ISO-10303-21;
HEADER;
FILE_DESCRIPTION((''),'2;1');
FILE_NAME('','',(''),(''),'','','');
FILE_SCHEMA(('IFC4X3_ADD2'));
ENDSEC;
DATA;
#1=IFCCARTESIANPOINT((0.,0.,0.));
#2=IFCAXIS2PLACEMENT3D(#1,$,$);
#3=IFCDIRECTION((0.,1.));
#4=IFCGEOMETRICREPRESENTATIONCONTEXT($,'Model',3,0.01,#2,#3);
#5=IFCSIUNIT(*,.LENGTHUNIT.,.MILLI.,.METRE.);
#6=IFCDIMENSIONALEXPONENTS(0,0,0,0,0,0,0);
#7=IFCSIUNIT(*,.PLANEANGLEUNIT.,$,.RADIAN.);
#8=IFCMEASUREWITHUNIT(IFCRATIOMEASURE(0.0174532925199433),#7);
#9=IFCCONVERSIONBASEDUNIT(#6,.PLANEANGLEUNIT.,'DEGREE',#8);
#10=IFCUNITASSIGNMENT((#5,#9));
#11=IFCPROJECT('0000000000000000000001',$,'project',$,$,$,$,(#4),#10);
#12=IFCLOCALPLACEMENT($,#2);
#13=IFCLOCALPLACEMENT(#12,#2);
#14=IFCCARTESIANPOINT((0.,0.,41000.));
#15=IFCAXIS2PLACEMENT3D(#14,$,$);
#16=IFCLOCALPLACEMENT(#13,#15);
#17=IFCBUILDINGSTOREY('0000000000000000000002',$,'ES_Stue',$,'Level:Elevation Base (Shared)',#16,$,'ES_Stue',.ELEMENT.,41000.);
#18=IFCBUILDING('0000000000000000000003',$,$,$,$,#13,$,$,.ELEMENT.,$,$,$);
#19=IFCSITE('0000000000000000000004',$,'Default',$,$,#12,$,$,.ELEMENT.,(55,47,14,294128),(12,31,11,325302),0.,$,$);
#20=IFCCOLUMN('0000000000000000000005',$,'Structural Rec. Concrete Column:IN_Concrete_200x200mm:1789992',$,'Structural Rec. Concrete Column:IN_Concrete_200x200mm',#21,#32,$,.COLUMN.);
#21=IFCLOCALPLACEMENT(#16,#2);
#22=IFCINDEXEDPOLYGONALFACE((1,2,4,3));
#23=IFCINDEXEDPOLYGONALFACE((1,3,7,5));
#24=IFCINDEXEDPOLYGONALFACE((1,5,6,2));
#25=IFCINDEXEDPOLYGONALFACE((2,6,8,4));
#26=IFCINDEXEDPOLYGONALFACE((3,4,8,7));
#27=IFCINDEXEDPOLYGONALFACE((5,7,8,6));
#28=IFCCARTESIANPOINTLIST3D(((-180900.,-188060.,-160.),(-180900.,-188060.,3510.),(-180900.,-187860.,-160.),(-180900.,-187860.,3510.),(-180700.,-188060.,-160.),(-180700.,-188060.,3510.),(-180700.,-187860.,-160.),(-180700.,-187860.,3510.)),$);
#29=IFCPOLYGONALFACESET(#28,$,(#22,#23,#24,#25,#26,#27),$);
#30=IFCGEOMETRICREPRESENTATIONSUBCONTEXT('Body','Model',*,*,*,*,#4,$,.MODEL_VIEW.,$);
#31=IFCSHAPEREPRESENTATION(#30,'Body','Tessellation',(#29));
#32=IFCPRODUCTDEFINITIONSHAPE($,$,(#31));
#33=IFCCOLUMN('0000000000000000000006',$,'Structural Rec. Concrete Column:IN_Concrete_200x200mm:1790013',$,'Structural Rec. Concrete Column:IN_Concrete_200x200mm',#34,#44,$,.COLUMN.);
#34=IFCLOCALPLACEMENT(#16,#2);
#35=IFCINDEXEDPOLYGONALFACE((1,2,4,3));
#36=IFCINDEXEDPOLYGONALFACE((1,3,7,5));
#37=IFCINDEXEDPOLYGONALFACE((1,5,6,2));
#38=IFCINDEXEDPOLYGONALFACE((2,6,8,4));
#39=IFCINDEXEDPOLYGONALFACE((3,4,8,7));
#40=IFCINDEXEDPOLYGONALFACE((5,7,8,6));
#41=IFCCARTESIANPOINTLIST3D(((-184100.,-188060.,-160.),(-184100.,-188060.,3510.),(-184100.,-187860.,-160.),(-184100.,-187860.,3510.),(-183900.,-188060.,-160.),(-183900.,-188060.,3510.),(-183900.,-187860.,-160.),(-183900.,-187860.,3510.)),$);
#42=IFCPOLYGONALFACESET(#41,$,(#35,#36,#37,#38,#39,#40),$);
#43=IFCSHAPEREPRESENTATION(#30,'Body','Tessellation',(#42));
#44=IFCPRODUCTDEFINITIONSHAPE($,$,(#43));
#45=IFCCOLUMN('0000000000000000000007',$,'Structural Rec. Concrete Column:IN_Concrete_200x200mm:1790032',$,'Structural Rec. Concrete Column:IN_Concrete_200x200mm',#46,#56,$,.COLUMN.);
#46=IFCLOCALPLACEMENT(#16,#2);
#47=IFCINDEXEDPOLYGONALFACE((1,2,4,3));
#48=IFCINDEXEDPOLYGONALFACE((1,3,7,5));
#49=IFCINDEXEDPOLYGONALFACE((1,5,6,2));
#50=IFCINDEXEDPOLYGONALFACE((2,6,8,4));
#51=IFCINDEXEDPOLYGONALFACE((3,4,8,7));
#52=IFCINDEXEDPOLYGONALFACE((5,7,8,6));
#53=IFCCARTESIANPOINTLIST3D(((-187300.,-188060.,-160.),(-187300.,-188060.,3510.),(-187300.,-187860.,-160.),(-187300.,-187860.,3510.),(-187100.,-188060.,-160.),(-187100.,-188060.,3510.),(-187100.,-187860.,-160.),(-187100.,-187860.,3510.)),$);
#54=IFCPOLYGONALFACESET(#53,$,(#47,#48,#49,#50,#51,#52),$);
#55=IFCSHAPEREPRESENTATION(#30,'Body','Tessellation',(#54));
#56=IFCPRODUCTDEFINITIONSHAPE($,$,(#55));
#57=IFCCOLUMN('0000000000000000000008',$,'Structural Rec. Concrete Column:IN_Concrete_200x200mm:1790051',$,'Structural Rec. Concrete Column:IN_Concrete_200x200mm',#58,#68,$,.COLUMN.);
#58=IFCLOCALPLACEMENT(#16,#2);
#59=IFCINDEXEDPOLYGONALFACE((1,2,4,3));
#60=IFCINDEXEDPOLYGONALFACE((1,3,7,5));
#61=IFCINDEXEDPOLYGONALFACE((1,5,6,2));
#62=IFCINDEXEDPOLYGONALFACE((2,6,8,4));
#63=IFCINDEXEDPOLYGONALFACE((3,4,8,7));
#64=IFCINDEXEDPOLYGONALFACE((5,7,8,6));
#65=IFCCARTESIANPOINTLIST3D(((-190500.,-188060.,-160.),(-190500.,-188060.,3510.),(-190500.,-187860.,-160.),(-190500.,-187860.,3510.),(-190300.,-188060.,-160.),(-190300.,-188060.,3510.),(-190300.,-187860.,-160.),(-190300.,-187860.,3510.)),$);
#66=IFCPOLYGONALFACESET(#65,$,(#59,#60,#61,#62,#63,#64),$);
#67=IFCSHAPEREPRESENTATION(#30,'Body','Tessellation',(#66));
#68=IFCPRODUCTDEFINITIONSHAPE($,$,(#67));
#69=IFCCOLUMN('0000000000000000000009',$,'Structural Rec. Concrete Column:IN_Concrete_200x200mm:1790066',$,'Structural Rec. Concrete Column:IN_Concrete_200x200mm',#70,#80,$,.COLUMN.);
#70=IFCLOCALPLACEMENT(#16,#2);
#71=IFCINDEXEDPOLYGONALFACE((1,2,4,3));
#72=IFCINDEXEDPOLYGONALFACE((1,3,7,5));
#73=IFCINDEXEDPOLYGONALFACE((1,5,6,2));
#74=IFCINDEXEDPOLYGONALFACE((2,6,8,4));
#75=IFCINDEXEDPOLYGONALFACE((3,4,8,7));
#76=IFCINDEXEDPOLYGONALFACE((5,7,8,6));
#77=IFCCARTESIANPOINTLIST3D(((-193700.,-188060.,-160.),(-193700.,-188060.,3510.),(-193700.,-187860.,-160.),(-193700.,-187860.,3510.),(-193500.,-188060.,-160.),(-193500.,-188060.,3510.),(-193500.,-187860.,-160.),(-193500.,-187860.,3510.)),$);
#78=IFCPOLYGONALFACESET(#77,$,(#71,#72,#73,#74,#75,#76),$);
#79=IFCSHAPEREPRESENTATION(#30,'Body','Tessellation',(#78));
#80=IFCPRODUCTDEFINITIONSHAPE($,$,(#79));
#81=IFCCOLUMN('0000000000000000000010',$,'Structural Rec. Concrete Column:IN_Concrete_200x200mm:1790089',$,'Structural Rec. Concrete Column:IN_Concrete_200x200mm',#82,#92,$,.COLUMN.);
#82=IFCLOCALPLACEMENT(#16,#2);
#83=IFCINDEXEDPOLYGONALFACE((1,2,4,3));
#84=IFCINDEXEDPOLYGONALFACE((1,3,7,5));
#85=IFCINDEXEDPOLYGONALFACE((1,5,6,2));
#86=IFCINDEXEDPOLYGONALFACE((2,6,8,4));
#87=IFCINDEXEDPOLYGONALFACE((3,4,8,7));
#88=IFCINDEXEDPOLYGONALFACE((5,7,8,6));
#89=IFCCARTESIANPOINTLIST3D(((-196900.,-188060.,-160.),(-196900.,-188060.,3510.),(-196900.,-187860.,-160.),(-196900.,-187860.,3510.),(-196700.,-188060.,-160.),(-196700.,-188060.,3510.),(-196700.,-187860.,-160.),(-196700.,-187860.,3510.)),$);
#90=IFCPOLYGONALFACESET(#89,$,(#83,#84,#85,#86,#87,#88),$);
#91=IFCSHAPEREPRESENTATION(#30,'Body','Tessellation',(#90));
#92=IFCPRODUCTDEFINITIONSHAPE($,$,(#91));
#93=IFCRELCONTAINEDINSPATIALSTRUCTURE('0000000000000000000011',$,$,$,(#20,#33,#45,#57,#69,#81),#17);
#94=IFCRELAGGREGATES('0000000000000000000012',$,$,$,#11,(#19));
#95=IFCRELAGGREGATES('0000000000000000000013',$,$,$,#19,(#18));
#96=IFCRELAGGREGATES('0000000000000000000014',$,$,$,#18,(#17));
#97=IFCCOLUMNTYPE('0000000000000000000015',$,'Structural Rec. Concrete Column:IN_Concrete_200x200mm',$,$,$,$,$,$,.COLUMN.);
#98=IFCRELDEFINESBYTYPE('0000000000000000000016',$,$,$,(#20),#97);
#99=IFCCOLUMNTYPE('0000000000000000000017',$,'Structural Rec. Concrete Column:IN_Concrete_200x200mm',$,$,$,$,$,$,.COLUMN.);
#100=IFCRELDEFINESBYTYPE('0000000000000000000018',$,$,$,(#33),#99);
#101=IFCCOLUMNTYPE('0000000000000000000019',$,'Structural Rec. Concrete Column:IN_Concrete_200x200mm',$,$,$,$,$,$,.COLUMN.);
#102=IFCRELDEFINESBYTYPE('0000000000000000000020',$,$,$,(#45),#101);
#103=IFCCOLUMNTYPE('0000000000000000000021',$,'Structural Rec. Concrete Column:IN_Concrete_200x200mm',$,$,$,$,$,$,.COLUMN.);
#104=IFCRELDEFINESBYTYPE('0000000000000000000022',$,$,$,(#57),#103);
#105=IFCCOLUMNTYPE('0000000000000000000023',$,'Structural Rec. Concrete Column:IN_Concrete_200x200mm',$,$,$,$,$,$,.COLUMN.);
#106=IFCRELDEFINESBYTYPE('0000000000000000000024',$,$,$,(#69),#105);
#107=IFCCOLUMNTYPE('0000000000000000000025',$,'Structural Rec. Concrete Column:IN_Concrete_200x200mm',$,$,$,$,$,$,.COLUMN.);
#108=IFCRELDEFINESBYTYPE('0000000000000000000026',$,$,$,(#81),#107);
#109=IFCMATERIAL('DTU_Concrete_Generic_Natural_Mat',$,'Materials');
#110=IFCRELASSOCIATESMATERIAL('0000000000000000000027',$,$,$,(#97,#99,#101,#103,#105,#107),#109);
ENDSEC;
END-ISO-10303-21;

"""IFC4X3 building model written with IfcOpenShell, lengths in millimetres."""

from ifc_helpers import new_model, entity, si_unit, converted_unit, direction, frame, origin, origin_2d_with_axis, place, context, subcontext, project, spatial, rectangle, extrude, source, transform, mapped, material, material_profile, profile_set, type_object, type_shapes, element, save


model = new_model("IFC4X3")

# Units and contexts
model_context = context("Model", 3, precision=0.01, world=origin(), true_north=direction((0.0, 1.0)))
body_context = subcontext(model_context, "Body", "Model", "MODEL_VIEW")
ifc_project = project(units=[si_unit("LENGTHUNIT", "METRE", prefix="MILLI"), converted_unit("PLANEANGLEUNIT", "DEGREE", entity("IfcRatioMeasure", 0.0174532925199433), si_unit("PLANEANGLEUNIT", "RADIAN"), dimensions=[0, 0, 0, 0, 0, 0, 0])], contexts=[model_context])

# Site, building, storey
site_placement = place(None, origin())
site = spatial("IfcSite", under=ifc_project, at=site_placement, Name="Default", CompositionType="ELEMENT", RefLatitude=(55, 47, 14, 294128), RefLongitude=(12, 31, 11, 325302), RefElevation=0.0)
building_placement = place(site_placement, origin())
building = spatial("IfcBuilding", under=site, at=building_placement, CompositionType="ELEMENT")
storey_placement = place(building_placement, frame((0.0, 0.0, 41000.0)))
storey = spatial("IfcBuildingStorey", under=building, at=storey_placement, Name="ES_Stue", ObjectType="Level:Elevation Base (Shared)", LongName="ES_Stue", CompositionType="ELEMENT", Elevation=41000.0)

# Columns
ifc_material = material(Name="DTU_Concrete_Generic_Natural_Mat", Category="Materials")
ifc_material_profile_1 = material_profile(ifc_material, rectangle(XDim=200.0, YDim=200.0, at=origin_2d_with_axis()), Name="IN_Concrete_200x200mm")
ifc_profile_set_1 = profile_set([ifc_material_profile_1], Name="IN_Concrete_200x200mm")
column_type_1 = type_object("IfcColumnType", Name="Structural Rec. Concrete Column:IN_Concrete_200x200mm", PredefinedType="COLUMN", material=ifc_profile_set_1)
shared_shape_1 = source(origin(), body_context, "Body", "SweptSolid", [
    extrude(rectangle(XDim=200.0, YDim=200.0, at=origin_2d_with_axis()), frame((-180800.0, -187960.0, 40840.0), z_axis=(0.0, 0.0, 1.0), x_axis=(0.0, -1.0, 0.0)), (0.0, 0.0, 1.0), 3670.0),
])
type_shapes(column_type_1, [shared_shape_1])
column_1_placement = place(storey_placement, frame((0.0, 0.0, -41000.0)))
element("IfcColumn", 1, at=column_1_placement, inside=storey, type_object=column_type_1, Name="Structural Rec. Concrete Column:IN_Concrete_200x200mm:1789992", ObjectType="Structural Rec. Concrete Column:IN_Concrete_200x200mm", PredefinedType="COLUMN", context=body_context, shape_type="MappedRepresentation", body=[
    mapped(shared_shape_1, transform((0.0, 0.0, 0.0), scale=1.0)),
])
column_type_2 = type_object("IfcColumnType", Name="Structural Rec. Concrete Column:IN_Concrete_200x200mm", PredefinedType="COLUMN", material=ifc_profile_set_1)
shared_shape_2 = source(origin(), body_context, "Body", "SweptSolid", [
    extrude(rectangle(XDim=200.0, YDim=200.0, at=origin_2d_with_axis()), frame((-184000.0, -187960.0, 40840.0), z_axis=(0.0, 0.0, 1.0), x_axis=(0.0, -1.0, 0.0)), (0.0, 0.0, 1.0), 3670.0),
])
type_shapes(column_type_2, [shared_shape_2])
column_2_placement = place(storey_placement, frame((0.0, 0.0, -41000.0)))
element("IfcColumn", 2, at=column_2_placement, inside=storey, type_object=column_type_2, Name="Structural Rec. Concrete Column:IN_Concrete_200x200mm:1790013", ObjectType="Structural Rec. Concrete Column:IN_Concrete_200x200mm", PredefinedType="COLUMN", context=body_context, shape_type="MappedRepresentation", body=[
    mapped(shared_shape_2, transform((0.0, 0.0, 0.0), scale=1.0)),
])
column_type_3 = type_object("IfcColumnType", Name="Structural Rec. Concrete Column:IN_Concrete_200x200mm", PredefinedType="COLUMN", material=ifc_profile_set_1)
shared_shape_3 = source(origin(), body_context, "Body", "SweptSolid", [
    extrude(rectangle(XDim=200.0, YDim=200.0, at=origin_2d_with_axis()), frame((-187200.0, -187960.0, 40840.0), z_axis=(0.0, 0.0, 1.0), x_axis=(0.0, -1.0, 0.0)), (0.0, 0.0, 1.0), 3670.0),
])
type_shapes(column_type_3, [shared_shape_3])
column_3_placement = place(storey_placement, frame((0.0, 0.0, -41000.0)))
element("IfcColumn", 3, at=column_3_placement, inside=storey, type_object=column_type_3, Name="Structural Rec. Concrete Column:IN_Concrete_200x200mm:1790032", ObjectType="Structural Rec. Concrete Column:IN_Concrete_200x200mm", PredefinedType="COLUMN", context=body_context, shape_type="MappedRepresentation", body=[
    mapped(shared_shape_3, transform((0.0, 0.0, 0.0), scale=1.0)),
])
column_type_4 = type_object("IfcColumnType", Name="Structural Rec. Concrete Column:IN_Concrete_200x200mm", PredefinedType="COLUMN", material=ifc_profile_set_1)
shared_shape_4 = source(origin(), body_context, "Body", "SweptSolid", [
    extrude(rectangle(XDim=200.0, YDim=200.0, at=origin_2d_with_axis()), frame((-190400.0, -187960.0, 40840.0), z_axis=(0.0, 0.0, 1.0), x_axis=(0.0, -1.0, 0.0)), (0.0, 0.0, 1.0), 3670.0),
])
type_shapes(column_type_4, [shared_shape_4])
column_4_placement = place(storey_placement, frame((0.0, 0.0, -41000.0)))
element("IfcColumn", 4, at=column_4_placement, inside=storey, type_object=column_type_4, Name="Structural Rec. Concrete Column:IN_Concrete_200x200mm:1790051", ObjectType="Structural Rec. Concrete Column:IN_Concrete_200x200mm", PredefinedType="COLUMN", context=body_context, shape_type="MappedRepresentation", body=[
    mapped(shared_shape_4, transform((0.0, 0.0, 0.0), scale=1.0)),
])
column_type_5 = type_object("IfcColumnType", Name="Structural Rec. Concrete Column:IN_Concrete_200x200mm", PredefinedType="COLUMN", material=ifc_profile_set_1)
shared_shape_5 = source(origin(), body_context, "Body", "SweptSolid", [
    extrude(rectangle(XDim=200.0, YDim=200.0, at=origin_2d_with_axis()), frame((-193600.0, -187960.0, 40840.0), z_axis=(0.0, 0.0, 1.0), x_axis=(0.0, -1.0, 0.0)), (0.0, 0.0, 1.0), 3670.0),
])
type_shapes(column_type_5, [shared_shape_5])
column_5_placement = place(storey_placement, frame((0.0, 0.0, -41000.0)))
element("IfcColumn", 5, at=column_5_placement, inside=storey, type_object=column_type_5, Name="Structural Rec. Concrete Column:IN_Concrete_200x200mm:1790066", ObjectType="Structural Rec. Concrete Column:IN_Concrete_200x200mm", PredefinedType="COLUMN", context=body_context, shape_type="MappedRepresentation", body=[
    mapped(shared_shape_5, transform((0.0, 0.0, 0.0), scale=1.0)),
])
column_type_6 = type_object("IfcColumnType", Name="Structural Rec. Concrete Column:IN_Concrete_200x200mm", PredefinedType="COLUMN", material=ifc_profile_set_1)
shared_shape_6 = source(origin(), body_context, "Body", "SweptSolid", [
    extrude(rectangle(XDim=200.0, YDim=200.0, at=origin_2d_with_axis()), frame((-196800.0, -187960.0, 40840.0), z_axis=(0.0, 0.0, 1.0), x_axis=(0.0, -1.0, 0.0)), (0.0, 0.0, 1.0), 3670.0),
])
type_shapes(column_type_6, [shared_shape_6])
column_6_placement = place(storey_placement, frame((0.0, 0.0, -41000.0)))
element("IfcColumn", 6, at=column_6_placement, inside=storey, type_object=column_type_6, Name="Structural Rec. Concrete Column:IN_Concrete_200x200mm:1790089", ObjectType="Structural Rec. Concrete Column:IN_Concrete_200x200mm", PredefinedType="COLUMN", context=body_context, shape_type="MappedRepresentation", body=[
    mapped(shared_shape_6, transform((0.0, 0.0, 0.0), scale=1.0)),
])

save(model, "model.ifc")
